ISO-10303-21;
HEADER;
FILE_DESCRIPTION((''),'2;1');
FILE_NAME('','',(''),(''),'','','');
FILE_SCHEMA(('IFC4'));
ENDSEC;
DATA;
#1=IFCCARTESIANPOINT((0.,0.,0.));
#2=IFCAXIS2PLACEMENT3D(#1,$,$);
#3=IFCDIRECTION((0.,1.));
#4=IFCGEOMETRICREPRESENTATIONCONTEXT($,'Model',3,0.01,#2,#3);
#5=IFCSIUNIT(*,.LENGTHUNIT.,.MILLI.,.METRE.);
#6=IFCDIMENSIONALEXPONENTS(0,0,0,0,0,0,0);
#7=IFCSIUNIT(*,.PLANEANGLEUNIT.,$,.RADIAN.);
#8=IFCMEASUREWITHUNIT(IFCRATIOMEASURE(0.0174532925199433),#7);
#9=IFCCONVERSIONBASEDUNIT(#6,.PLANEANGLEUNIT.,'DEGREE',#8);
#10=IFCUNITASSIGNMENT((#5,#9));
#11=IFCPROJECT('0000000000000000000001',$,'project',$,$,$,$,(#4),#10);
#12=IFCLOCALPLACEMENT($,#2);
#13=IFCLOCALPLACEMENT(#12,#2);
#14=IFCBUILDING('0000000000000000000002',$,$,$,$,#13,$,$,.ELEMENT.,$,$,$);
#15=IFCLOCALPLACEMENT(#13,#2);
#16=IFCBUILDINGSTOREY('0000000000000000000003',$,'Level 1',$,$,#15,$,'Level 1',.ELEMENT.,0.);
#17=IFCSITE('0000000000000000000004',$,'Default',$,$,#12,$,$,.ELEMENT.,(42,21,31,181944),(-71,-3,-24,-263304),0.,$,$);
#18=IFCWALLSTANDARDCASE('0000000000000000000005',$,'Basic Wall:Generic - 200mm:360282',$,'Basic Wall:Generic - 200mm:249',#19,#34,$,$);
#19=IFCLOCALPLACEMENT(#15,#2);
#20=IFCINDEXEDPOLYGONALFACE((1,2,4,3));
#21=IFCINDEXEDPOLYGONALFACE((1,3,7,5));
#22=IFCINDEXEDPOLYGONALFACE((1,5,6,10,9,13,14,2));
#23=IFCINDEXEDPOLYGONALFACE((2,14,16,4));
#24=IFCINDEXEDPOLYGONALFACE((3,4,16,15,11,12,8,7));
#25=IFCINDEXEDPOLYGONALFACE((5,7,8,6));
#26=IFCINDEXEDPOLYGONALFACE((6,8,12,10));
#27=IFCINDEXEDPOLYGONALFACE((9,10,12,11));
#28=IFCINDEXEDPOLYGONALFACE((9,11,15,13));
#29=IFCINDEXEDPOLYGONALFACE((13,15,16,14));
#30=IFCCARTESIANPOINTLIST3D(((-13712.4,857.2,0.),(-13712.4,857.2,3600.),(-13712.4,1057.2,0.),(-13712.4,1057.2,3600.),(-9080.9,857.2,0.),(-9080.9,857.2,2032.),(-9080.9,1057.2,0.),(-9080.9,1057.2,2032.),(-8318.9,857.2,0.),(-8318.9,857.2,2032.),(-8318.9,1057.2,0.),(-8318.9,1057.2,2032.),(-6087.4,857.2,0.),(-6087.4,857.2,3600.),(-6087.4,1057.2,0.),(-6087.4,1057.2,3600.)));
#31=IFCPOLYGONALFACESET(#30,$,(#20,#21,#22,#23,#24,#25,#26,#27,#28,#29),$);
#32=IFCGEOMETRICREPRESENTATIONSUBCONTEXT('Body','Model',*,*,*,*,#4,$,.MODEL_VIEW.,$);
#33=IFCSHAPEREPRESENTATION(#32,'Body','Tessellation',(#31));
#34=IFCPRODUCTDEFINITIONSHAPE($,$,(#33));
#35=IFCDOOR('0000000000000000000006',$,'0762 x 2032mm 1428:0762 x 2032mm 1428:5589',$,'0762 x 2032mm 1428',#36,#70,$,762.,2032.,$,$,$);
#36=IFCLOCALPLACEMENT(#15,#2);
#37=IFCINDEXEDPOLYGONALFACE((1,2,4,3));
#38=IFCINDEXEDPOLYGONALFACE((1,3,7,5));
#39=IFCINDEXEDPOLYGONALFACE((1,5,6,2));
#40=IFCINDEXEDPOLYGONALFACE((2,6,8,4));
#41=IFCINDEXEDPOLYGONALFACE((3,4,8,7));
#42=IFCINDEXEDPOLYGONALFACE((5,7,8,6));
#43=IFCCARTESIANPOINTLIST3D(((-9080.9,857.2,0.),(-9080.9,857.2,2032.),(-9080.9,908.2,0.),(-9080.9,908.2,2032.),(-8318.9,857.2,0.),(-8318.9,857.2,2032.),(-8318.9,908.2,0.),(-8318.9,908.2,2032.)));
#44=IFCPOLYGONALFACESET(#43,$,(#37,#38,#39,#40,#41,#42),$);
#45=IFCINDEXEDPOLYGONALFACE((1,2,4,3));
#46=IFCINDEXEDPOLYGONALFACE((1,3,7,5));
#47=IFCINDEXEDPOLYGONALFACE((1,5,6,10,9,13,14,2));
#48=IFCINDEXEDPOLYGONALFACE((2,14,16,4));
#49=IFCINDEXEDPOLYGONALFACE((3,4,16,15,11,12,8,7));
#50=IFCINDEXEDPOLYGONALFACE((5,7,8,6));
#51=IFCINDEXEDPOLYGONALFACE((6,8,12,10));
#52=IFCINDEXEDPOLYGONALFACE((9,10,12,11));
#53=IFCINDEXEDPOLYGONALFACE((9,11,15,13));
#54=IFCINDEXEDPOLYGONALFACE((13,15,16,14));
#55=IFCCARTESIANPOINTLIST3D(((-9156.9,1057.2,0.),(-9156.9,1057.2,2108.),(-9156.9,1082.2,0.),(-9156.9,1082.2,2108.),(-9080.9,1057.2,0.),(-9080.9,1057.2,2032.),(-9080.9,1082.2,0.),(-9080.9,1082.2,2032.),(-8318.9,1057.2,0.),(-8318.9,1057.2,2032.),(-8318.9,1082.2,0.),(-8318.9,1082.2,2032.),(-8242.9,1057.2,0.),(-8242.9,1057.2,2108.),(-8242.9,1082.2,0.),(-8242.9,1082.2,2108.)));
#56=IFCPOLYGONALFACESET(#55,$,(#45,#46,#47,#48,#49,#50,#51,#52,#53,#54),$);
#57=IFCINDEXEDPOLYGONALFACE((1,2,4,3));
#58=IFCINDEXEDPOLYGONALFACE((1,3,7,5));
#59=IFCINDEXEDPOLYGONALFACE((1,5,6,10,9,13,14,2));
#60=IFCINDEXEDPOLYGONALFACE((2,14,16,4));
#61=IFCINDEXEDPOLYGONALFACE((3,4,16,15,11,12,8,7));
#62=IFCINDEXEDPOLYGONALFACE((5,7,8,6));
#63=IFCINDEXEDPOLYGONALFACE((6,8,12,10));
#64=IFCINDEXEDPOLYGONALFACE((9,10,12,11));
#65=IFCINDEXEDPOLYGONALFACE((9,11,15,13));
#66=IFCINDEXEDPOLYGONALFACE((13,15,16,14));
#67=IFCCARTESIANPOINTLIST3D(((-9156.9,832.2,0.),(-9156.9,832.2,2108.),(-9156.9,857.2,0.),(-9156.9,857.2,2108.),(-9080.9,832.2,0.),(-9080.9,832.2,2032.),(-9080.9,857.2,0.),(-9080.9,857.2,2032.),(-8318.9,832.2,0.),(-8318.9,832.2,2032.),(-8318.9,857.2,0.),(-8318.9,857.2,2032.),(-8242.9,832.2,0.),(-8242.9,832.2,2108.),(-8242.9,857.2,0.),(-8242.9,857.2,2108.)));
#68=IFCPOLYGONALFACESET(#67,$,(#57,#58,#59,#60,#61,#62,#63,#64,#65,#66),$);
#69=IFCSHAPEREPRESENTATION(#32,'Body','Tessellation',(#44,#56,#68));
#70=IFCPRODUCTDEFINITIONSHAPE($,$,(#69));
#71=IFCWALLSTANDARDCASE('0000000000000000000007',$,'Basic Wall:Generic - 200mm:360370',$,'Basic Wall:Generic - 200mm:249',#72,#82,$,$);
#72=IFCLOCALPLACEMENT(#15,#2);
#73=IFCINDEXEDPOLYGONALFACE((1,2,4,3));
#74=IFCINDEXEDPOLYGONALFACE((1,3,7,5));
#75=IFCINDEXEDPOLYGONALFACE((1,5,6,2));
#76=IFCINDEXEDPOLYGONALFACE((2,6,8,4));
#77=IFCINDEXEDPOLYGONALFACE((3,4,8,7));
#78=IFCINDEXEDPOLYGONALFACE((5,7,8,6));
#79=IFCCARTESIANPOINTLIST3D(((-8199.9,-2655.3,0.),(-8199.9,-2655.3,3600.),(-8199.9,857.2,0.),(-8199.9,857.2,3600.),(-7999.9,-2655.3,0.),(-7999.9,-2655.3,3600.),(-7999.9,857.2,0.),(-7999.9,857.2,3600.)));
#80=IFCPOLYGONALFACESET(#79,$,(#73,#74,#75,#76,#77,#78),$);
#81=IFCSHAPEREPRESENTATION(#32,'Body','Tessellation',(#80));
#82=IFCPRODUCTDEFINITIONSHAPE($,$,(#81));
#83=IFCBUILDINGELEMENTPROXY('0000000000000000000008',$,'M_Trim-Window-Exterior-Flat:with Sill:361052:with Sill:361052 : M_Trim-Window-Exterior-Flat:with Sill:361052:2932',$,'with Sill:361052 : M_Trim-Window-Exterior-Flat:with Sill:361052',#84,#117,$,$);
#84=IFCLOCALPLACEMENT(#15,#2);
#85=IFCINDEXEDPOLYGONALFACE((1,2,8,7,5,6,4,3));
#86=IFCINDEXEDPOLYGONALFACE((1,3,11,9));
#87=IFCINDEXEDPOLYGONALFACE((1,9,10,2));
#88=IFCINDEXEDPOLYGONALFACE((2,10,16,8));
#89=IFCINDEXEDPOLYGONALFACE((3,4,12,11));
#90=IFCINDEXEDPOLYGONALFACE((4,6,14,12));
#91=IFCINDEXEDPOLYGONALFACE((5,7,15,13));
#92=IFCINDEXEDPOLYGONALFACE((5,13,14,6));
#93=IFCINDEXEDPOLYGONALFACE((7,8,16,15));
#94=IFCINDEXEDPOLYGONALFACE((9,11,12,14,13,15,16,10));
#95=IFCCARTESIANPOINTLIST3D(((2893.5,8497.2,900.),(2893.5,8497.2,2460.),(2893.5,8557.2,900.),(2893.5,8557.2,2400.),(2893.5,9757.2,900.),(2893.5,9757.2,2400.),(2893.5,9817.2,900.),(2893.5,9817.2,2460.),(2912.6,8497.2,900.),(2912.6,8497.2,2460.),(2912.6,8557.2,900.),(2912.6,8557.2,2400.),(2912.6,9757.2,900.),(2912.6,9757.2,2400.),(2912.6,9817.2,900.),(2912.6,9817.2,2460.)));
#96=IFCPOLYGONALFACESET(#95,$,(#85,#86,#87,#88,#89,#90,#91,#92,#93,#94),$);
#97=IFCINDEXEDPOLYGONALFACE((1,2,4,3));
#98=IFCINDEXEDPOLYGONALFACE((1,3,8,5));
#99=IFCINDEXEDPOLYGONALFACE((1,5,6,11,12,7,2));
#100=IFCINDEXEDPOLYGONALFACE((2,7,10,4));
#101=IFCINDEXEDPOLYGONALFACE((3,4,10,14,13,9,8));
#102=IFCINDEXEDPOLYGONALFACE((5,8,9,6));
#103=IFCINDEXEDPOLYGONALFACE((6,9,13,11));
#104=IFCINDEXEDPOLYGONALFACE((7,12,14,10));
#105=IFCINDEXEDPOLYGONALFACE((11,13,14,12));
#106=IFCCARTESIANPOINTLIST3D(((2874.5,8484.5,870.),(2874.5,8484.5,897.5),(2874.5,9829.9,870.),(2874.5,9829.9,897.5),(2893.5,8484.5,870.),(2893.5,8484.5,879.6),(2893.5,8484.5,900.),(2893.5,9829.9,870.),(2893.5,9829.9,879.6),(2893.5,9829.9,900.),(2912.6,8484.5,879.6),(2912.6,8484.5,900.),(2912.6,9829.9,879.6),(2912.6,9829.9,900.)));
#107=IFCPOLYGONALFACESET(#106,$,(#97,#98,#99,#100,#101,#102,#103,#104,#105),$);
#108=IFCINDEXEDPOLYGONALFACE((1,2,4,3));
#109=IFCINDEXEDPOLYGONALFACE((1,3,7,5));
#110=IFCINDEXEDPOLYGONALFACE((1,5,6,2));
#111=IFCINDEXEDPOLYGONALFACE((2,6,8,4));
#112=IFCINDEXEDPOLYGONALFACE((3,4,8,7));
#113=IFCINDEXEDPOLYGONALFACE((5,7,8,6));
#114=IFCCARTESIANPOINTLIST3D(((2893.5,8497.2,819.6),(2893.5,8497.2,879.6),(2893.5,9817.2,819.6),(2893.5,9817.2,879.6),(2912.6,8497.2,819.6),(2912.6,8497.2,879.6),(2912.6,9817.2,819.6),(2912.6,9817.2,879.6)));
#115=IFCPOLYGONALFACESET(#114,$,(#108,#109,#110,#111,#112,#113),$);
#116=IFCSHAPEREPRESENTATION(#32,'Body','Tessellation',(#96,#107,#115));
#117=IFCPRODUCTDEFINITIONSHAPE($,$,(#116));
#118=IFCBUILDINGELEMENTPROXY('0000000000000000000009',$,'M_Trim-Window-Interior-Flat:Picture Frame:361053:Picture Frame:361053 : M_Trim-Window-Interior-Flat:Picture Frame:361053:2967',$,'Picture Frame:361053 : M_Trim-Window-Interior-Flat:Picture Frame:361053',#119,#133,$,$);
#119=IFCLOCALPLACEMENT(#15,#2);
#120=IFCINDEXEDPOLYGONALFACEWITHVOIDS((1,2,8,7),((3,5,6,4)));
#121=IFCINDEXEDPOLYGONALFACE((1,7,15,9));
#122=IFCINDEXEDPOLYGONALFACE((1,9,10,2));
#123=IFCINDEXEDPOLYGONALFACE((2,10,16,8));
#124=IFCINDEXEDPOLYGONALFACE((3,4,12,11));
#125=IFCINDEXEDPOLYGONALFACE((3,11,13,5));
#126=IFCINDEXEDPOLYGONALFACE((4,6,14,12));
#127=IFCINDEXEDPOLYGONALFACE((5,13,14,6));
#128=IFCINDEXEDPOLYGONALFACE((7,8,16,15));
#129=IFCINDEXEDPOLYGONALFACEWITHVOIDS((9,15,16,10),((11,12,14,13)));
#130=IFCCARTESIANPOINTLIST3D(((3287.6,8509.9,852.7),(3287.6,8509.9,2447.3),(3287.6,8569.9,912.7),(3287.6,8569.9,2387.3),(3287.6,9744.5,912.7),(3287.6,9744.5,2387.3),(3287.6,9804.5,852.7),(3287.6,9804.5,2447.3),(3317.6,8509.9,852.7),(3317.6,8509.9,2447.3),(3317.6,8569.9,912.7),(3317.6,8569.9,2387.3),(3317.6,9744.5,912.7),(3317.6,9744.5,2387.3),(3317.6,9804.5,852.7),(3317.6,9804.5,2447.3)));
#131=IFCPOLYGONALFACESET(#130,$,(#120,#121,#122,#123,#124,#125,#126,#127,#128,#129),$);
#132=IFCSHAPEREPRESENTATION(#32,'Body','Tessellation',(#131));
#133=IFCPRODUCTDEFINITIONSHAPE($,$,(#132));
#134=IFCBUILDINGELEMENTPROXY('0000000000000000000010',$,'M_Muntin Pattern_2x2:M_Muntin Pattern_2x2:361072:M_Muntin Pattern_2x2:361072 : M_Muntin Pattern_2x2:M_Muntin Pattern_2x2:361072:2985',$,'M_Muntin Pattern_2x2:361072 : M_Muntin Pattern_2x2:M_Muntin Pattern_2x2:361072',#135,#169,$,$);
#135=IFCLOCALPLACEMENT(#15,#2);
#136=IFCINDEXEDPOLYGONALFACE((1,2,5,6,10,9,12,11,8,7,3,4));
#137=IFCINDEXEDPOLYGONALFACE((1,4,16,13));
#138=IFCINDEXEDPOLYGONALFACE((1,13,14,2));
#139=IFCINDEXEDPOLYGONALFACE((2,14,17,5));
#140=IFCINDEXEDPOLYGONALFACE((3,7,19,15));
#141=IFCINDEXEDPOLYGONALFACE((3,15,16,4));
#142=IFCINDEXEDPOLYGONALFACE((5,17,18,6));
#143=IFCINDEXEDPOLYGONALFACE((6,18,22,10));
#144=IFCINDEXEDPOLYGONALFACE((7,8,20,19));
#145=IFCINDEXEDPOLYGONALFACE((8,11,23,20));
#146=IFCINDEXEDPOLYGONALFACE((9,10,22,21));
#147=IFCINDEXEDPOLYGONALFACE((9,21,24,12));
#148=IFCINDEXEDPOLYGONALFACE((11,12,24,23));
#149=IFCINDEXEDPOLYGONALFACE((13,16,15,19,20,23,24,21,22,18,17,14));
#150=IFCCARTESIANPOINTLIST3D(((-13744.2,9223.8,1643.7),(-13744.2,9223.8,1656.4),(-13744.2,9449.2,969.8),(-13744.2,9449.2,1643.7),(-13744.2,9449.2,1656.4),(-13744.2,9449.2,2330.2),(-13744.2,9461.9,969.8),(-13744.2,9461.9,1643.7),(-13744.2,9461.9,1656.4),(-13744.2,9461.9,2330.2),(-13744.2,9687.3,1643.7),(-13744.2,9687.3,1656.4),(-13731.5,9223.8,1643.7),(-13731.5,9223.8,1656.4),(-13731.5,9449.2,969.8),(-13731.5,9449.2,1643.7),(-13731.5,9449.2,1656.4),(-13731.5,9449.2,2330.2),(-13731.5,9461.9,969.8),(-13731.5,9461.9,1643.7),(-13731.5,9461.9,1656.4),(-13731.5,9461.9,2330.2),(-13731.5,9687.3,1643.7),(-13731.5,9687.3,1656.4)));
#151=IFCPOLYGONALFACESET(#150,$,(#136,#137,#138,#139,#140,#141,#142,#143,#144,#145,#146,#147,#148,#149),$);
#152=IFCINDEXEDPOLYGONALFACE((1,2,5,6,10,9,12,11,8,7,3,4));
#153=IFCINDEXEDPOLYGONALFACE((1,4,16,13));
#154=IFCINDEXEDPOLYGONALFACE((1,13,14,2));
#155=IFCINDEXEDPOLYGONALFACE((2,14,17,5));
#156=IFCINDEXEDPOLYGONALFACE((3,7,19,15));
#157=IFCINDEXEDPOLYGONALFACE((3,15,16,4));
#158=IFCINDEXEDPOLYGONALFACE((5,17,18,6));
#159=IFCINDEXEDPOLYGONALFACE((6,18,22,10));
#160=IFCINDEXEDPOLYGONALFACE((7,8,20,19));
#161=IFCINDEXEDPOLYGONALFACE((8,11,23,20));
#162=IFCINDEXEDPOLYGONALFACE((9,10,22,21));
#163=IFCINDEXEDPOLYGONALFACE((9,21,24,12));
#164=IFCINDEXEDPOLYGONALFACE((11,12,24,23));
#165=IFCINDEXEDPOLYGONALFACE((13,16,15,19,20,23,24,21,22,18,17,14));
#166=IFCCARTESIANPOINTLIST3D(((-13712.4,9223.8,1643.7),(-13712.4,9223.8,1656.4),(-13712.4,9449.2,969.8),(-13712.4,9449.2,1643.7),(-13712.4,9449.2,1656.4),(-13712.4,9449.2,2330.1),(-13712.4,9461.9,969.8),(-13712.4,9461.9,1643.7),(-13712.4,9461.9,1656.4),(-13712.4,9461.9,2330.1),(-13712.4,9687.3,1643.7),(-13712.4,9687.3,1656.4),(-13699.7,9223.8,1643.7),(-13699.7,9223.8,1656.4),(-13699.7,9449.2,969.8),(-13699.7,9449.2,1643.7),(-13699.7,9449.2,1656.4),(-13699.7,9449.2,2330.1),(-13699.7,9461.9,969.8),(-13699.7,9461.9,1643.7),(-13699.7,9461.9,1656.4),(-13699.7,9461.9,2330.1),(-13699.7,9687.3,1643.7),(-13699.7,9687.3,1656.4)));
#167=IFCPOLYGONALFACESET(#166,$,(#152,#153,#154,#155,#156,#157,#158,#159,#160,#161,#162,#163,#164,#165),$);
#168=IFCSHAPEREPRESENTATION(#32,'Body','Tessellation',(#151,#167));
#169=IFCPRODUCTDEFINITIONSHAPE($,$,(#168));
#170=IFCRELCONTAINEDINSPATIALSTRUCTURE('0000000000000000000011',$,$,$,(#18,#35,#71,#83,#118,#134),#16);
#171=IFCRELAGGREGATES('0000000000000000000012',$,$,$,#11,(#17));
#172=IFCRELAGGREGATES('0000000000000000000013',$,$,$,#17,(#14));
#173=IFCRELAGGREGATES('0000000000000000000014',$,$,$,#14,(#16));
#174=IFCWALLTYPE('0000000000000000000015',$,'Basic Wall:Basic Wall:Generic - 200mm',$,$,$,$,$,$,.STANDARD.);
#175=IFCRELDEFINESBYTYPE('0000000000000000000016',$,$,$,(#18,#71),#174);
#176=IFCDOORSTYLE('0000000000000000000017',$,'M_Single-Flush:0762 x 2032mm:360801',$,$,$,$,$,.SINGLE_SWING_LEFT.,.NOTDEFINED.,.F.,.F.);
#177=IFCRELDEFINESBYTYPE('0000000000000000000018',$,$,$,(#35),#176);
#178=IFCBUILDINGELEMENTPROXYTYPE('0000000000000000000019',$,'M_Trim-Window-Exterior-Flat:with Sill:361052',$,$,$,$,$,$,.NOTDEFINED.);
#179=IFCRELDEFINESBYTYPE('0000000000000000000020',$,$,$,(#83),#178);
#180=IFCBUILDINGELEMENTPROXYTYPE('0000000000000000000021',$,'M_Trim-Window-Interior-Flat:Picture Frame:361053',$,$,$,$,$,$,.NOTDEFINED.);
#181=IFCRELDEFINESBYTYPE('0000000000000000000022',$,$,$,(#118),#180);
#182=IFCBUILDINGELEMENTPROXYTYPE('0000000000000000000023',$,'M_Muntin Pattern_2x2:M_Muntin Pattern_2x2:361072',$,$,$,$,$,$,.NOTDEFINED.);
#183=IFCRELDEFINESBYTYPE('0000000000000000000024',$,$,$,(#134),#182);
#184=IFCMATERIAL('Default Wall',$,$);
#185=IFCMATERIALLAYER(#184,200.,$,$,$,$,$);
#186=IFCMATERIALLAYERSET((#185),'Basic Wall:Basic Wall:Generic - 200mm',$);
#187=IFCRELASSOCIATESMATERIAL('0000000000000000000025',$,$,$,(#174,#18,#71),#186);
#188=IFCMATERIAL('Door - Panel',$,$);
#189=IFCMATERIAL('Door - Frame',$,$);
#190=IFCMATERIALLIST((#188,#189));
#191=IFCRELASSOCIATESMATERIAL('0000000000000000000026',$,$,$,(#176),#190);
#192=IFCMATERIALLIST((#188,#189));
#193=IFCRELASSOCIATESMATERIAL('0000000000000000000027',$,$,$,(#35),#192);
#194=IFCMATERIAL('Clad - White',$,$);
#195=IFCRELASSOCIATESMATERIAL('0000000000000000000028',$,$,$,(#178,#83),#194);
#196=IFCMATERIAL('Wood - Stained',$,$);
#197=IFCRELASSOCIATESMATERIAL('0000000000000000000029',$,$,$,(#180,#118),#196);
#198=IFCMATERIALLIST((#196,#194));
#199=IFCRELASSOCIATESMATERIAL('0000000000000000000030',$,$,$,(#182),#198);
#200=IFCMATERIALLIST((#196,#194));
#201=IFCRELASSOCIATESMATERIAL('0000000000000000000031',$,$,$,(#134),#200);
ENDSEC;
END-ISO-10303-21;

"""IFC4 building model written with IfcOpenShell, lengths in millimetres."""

from ifc_helpers import new_model, entity, si_unit, converted_unit, direction, frame, frame_2d, origin, origin_2d_with_axis, place, context, subcontext, project, spatial, polyline, rectangle, outline, extrude, source, transform, mapped, material, material_list, layer, layer_set, layer_usage, type_object, type_shapes, element, fill, save


model = new_model("IFC4")

# Units and contexts
model_context = context("Model", 3, precision=0.01, world=origin(), true_north=direction((0.0, 1.0)))
body_context = subcontext(model_context, "Body", "Model", "MODEL_VIEW")
ifc_project = project(units=[si_unit("LENGTHUNIT", "METRE", prefix="MILLI"), converted_unit("PLANEANGLEUNIT", "DEGREE", entity("IfcRatioMeasure", 0.0174532925199433), si_unit("PLANEANGLEUNIT", "RADIAN"), dimensions=[0, 0, 0, 0, 0, 0, 0])], contexts=[model_context])

# Site, building, storey
site_placement = place(None, origin())
site = spatial("IfcSite", under=ifc_project, at=site_placement, Name="Default", CompositionType="ELEMENT", RefLatitude=(42, 21, 31, 181944), RefLongitude=(-71, -3, -24, -263304), RefElevation=0.0)
building_placement = place(site_placement, origin())
building = spatial("IfcBuilding", under=site, at=building_placement, CompositionType="ELEMENT")
storey_placement = place(building_placement, origin())
storey = spatial("IfcBuildingStorey", under=building, at=storey_placement, Name="Level 1", LongName="Level 1", CompositionType="ELEMENT", Elevation=0.0)

# Shared definitions
ifc_material_1 = material(Name="Default Wall")
ifc_material_2 = material(Name="Door - Panel")
ifc_material_3 = material(Name="Door - Frame")

# Shared definitions
ifc_layer_1 = layer(ifc_material_1, 200.0)
ifc_layer_set_1 = layer_set([ifc_layer_1], Name="Basic Wall:Basic Wall:Generic - 200mm")
wall_type_1 = type_object("IfcWallType", Name="Basic Wall:Basic Wall:Generic - 200mm", PredefinedType="STANDARD", material=ifc_layer_set_1)
ifc_material_list_1 = material_list([ifc_material_2, ifc_material_3])
door_style_1 = type_object("IfcDoorStyle", Name="M_Single-Flush:0762 x 2032mm:360801", ConstructionType="NOTDEFINED", OperationType="SINGLE_SWING_LEFT", ParameterTakesPrecedence=False, Sizeable=False, material=ifc_material_list_1)
shared_shape_1 = source(origin(), body_context, "Body", "SweptSolid", [
    extrude(rectangle(XDim=51.0, YDim=762.0, at=origin_2d_with_axis()), frame((381.0, -27.5, 0.0), z_axis=(0.0, 0.0, 1.0), x_axis=(0.0, 1.0, 0.0)), (0.0, 0.0, 1.0), 2032.0),
    extrude(outline(polyline([(-1035.0, -457.0), (1073.0, -457.0), (1073.0, 457.0), (-1035.0, 457.0), (-1035.0, 381.0), (997.0, 381.0), (997.0, -381.0), (-1035.0, -381.0), (-1035.0, -457.0)])), frame((381.0, -227.0, 1035.0), z_axis=(0.0, 1.0, 0.0), x_axis=(0.0, 0.0, 1.0)), (0.0, 0.0, 1.0), 25.0),
    extrude(outline(polyline([(-457.0, -1073.0), (457.0, -1073.0), (457.0, 1035.0), (381.0, 1035.0), (381.0, -997.0), (-381.0, -997.0), (-381.0, 1035.0), (-457.0, 1035.0), (-457.0, -1073.0)])), frame((381.0, -2.0, 1035.0), z_axis=(0.0, 1.0, 0.0), x_axis=(1.0, 0.0, 0.0)), (0.0, 0.0, 1.0), 25.0),
])
type_shapes(door_style_1, [shared_shape_1])

# Wall, opening, door
ifc_layer_usage_1 = layer_usage(ifc_layer_set_1, "AXIS2", "NEGATIVE", 100.0)
wall_1_placement = place(storey_placement, frame((-6087.4, 957.2, 0.0), z_axis=(0.0, 0.0, 1.0), x_axis=(-1.0, 0.0, 0.0)))
wall_1 = element("IfcWallStandardCase", 1, at=wall_1_placement, inside=storey, type_object=wall_type_1, material=ifc_layer_usage_1, Name="Basic Wall:Generic - 200mm:360282", ObjectType="Basic Wall:Generic - 200mm:249", context=body_context, shape_type="SweptSolid", body=[
    extrude(rectangle(XDim=7625.0, YDim=200.0, at=frame_2d((3812.5, 0.0), x_axis=(-1.0, 0.0))), origin(), (0.0, 0.0, 1.0), 3600.0),
])
opening_1_placement = place(wall_1_placement, frame((-6087.4, 957.2, 0.0), z_axis=(0.0, 0.0, 1.0), x_axis=(-1.0, 0.0, 0.0)))
opening_1 = element("IfcOpeningElement", 2, at=opening_1_placement, cuts=wall_1, ObjectType="Opening", context=body_context, shape_type="SweptSolid", body=[
    extrude(rectangle(XDim=2032.0, YDim=762.0, at=origin_2d_with_axis()), frame((-8699.9, 1059.2, 1016.0), z_axis=(0.0, -1.0, 0.0), x_axis=(0.0, 0.0, 1.0)), (0.0, 0.0, 1.0), 204.0),
])
ifc_material_list_2 = material_list([ifc_material_2, ifc_material_3])
door_1_placement = place(opening_1_placement, frame((-8318.9, 855.2, 0.0), z_axis=(0.0, 0.0, 1.0), x_axis=(-1.0, 0.0, 0.0)))
door_1 = element("IfcDoor", 3, at=door_1_placement, inside=storey, type_object=door_style_1, material=ifc_material_list_2, Name="0762 x 2032mm 1428:0762 x 2032mm 1428:5589", ObjectType="0762 x 2032mm 1428", OverallHeight=762.0, OverallWidth=2032.0, context=body_context, shape_type="MappedRepresentation", body=[
    mapped(shared_shape_1, transform((0.0, 0.0, 0.0), scale=1.0)),
])
fill(opening_1, door_1)

# Wall
ifc_layer_usage_2 = layer_usage(ifc_layer_set_1, "AXIS2", "NEGATIVE", 100.0)
wall_2_placement = place(storey_placement, frame((-8099.9, 857.2, 0.0), z_axis=(0.0, 0.0, 1.0), x_axis=(0.0, -1.0, 0.0)))
element("IfcWallStandardCase", 4, at=wall_2_placement, inside=storey, type_object=wall_type_1, material=ifc_layer_usage_2, Name="Basic Wall:Generic - 200mm:360370", ObjectType="Basic Wall:Generic - 200mm:249", context=body_context, shape_type="SweptSolid", body=[
    extrude(rectangle(XDim=3512.5, YDim=200.0, at=frame_2d((1756.2, 0.0), x_axis=(-1.0, 0.0))), origin(), (0.0, 0.0, 1.0), 3600.0),
])

# Building element proxies
ifc_material_4 = material(Name="Clad - White")
building_element_proxy_type_1 = type_object("IfcBuildingElementProxyType", Name="M_Trim-Window-Exterior-Flat:with Sill:361052", PredefinedType="NOTDEFINED", material=ifc_material_4)
shared_shape_2 = source(origin(), body_context, "Body", "SweptSolid", [
    extrude(outline(polyline([(-765.0, -660.0), (795.0, -660.0), (795.0, 660.0), (-765.0, 660.0), (-765.0, 600.0), (735.0, 600.0), (735.0, -600.0), (-765.0, -600.0), (-765.0, -660.0)])), frame((2893.5, 9157.2, 1665.0), z_axis=(1.0, 0.0, 0.0), x_axis=(0.0, 0.0, 1.0)), (0.0, 0.0, 1.0), 19.1),
    extrude(outline(polyline([(0.0, -15.2), (19.0, -15.2), (19.0, 12.3), (0.0, 14.8), (-19.0, 14.8), (-19.0, -5.7), (0.0, -5.7), (0.0, -15.2)])), frame((2893.5, 8484.5, 885.2), z_axis=(0.0, 1.0, 0.0), x_axis=(-1.0, 0.0, 0.0)), (0.0, 0.0, 1.0), 1345.4),
    extrude(rectangle(XDim=19.1, YDim=1320.0, at=frame_2d((0.0, 0.0), x_axis=(1.0, 0.0))), frame((2903.0, 9157.2, 819.6)), (0.0, 0.0, 1.0), 60.0),
])
type_shapes(building_element_proxy_type_1, [shared_shape_2])
proxy_1_placement = place(storey_placement, origin())
element("IfcBuildingElementProxy", 5, at=proxy_1_placement, inside=storey, type_object=building_element_proxy_type_1, material=ifc_material_4, Name="M_Trim-Window-Exterior-Flat:with Sill:361052:with Sill:361052 : M_Trim-Window-Exterior-Flat:with Sill:361052:2932", ObjectType="with Sill:361052 : M_Trim-Window-Exterior-Flat:with Sill:361052", context=body_context, shape_type="MappedRepresentation", body=[
    mapped(shared_shape_2, transform((0.0, 0.0, 0.0), scale=1.0)),
])
ifc_material_5 = material(Name="Wood - Stained")
building_element_proxy_type_2 = type_object("IfcBuildingElementProxyType", Name="M_Trim-Window-Interior-Flat:Picture Frame:361053", PredefinedType="NOTDEFINED", material=ifc_material_5)
shared_shape_3 = source(origin(), body_context, "Body", "SweptSolid", [
    extrude(outline(polyline([(-797.3, -647.3), (797.3, -647.3), (797.3, 647.3), (-797.3, 647.3), (-797.3, -647.3)]), holes=[polyline([(737.3, 587.3), (737.3, -587.3), (-737.3, -587.3), (-737.3, 587.3), (737.3, 587.3)])]), frame((3287.6, 9157.2, 1650.0), z_axis=(1.0, 0.0, 0.0), x_axis=(0.0, 0.0, -1.0)), (0.0, 0.0, 1.0), 30.0),
])
type_shapes(building_element_proxy_type_2, [shared_shape_3])
proxy_2_placement = place(storey_placement, origin())
element("IfcBuildingElementProxy", 6, at=proxy_2_placement, inside=storey, type_object=building_element_proxy_type_2, material=ifc_material_5, Name="M_Trim-Window-Interior-Flat:Picture Frame:361053:Picture Frame:361053 : M_Trim-Window-Interior-Flat:Picture Frame:361053:2967", ObjectType="Picture Frame:361053 : M_Trim-Window-Interior-Flat:Picture Frame:361053", context=body_context, shape_type="MappedRepresentation", body=[
    mapped(shared_shape_3, transform((0.0, 0.0, 0.0), scale=1.0)),
])
ifc_material_list_3 = material_list([ifc_material_5, ifc_material_4])
ifc_material_list_4 = material_list([ifc_material_5, ifc_material_4])
building_element_proxy_type_3 = type_object("IfcBuildingElementProxyType", Name="M_Muntin Pattern_2x2:M_Muntin Pattern_2x2:361072", PredefinedType="NOTDEFINED", material=ifc_material_list_4)
shared_shape_4 = source(origin(), body_context, "Body", "SweptSolid", [
    extrude(outline(polyline([(-6.4, -680.2), (6.3, -680.2), (6.3, -6.4), (231.7, -6.4), (231.7, 6.3), (6.3, 6.3), (6.3, 680.2), (-6.4, 680.2), (-6.4, 6.3), (-231.7, 6.3), (-231.7, -6.4), (-6.4, -6.4), (-6.4, -680.2)])), frame((-13744.2, 9455.6, 1650.0), z_axis=(1.0, 0.0, 0.0), x_axis=(0.0, -1.0, 0.0)), (0.0, 0.0, 1.0), 12.7),
    extrude(outline(polyline([(-6.4, -680.1), (6.3, -680.1), (6.3, -6.4), (231.7, -6.4), (231.7, 6.3), (6.3, 6.3), (6.3, 680.2), (-6.4, 680.2), (-6.4, 6.3), (-231.7, 6.3), (-231.7, -6.4), (-6.4, -6.4), (-6.4, -680.1)])), frame((-13712.4, 9455.6, 1650.0), z_axis=(1.0, 0.0, 0.0), x_axis=(0.0, -1.0, 0.0)), (0.0, 0.0, 1.0), 12.7),
])
type_shapes(building_element_proxy_type_3, [shared_shape_4])
proxy_3_placement = place(storey_placement, origin())
element("IfcBuildingElementProxy", 7, at=proxy_3_placement, inside=storey, type_object=building_element_proxy_type_3, material=ifc_material_list_3, Name="M_Muntin Pattern_2x2:M_Muntin Pattern_2x2:361072:M_Muntin Pattern_2x2:361072 : M_Muntin Pattern_2x2:M_Muntin Pattern_2x2:361072:2985", ObjectType="M_Muntin Pattern_2x2:361072 : M_Muntin Pattern_2x2:M_Muntin Pattern_2x2:361072", context=body_context, shape_type="MappedRepresentation", body=[
    mapped(shared_shape_4, transform((0.0, 0.0, 0.0), scale=1.0)),
])

save(model, "model.ifc")
